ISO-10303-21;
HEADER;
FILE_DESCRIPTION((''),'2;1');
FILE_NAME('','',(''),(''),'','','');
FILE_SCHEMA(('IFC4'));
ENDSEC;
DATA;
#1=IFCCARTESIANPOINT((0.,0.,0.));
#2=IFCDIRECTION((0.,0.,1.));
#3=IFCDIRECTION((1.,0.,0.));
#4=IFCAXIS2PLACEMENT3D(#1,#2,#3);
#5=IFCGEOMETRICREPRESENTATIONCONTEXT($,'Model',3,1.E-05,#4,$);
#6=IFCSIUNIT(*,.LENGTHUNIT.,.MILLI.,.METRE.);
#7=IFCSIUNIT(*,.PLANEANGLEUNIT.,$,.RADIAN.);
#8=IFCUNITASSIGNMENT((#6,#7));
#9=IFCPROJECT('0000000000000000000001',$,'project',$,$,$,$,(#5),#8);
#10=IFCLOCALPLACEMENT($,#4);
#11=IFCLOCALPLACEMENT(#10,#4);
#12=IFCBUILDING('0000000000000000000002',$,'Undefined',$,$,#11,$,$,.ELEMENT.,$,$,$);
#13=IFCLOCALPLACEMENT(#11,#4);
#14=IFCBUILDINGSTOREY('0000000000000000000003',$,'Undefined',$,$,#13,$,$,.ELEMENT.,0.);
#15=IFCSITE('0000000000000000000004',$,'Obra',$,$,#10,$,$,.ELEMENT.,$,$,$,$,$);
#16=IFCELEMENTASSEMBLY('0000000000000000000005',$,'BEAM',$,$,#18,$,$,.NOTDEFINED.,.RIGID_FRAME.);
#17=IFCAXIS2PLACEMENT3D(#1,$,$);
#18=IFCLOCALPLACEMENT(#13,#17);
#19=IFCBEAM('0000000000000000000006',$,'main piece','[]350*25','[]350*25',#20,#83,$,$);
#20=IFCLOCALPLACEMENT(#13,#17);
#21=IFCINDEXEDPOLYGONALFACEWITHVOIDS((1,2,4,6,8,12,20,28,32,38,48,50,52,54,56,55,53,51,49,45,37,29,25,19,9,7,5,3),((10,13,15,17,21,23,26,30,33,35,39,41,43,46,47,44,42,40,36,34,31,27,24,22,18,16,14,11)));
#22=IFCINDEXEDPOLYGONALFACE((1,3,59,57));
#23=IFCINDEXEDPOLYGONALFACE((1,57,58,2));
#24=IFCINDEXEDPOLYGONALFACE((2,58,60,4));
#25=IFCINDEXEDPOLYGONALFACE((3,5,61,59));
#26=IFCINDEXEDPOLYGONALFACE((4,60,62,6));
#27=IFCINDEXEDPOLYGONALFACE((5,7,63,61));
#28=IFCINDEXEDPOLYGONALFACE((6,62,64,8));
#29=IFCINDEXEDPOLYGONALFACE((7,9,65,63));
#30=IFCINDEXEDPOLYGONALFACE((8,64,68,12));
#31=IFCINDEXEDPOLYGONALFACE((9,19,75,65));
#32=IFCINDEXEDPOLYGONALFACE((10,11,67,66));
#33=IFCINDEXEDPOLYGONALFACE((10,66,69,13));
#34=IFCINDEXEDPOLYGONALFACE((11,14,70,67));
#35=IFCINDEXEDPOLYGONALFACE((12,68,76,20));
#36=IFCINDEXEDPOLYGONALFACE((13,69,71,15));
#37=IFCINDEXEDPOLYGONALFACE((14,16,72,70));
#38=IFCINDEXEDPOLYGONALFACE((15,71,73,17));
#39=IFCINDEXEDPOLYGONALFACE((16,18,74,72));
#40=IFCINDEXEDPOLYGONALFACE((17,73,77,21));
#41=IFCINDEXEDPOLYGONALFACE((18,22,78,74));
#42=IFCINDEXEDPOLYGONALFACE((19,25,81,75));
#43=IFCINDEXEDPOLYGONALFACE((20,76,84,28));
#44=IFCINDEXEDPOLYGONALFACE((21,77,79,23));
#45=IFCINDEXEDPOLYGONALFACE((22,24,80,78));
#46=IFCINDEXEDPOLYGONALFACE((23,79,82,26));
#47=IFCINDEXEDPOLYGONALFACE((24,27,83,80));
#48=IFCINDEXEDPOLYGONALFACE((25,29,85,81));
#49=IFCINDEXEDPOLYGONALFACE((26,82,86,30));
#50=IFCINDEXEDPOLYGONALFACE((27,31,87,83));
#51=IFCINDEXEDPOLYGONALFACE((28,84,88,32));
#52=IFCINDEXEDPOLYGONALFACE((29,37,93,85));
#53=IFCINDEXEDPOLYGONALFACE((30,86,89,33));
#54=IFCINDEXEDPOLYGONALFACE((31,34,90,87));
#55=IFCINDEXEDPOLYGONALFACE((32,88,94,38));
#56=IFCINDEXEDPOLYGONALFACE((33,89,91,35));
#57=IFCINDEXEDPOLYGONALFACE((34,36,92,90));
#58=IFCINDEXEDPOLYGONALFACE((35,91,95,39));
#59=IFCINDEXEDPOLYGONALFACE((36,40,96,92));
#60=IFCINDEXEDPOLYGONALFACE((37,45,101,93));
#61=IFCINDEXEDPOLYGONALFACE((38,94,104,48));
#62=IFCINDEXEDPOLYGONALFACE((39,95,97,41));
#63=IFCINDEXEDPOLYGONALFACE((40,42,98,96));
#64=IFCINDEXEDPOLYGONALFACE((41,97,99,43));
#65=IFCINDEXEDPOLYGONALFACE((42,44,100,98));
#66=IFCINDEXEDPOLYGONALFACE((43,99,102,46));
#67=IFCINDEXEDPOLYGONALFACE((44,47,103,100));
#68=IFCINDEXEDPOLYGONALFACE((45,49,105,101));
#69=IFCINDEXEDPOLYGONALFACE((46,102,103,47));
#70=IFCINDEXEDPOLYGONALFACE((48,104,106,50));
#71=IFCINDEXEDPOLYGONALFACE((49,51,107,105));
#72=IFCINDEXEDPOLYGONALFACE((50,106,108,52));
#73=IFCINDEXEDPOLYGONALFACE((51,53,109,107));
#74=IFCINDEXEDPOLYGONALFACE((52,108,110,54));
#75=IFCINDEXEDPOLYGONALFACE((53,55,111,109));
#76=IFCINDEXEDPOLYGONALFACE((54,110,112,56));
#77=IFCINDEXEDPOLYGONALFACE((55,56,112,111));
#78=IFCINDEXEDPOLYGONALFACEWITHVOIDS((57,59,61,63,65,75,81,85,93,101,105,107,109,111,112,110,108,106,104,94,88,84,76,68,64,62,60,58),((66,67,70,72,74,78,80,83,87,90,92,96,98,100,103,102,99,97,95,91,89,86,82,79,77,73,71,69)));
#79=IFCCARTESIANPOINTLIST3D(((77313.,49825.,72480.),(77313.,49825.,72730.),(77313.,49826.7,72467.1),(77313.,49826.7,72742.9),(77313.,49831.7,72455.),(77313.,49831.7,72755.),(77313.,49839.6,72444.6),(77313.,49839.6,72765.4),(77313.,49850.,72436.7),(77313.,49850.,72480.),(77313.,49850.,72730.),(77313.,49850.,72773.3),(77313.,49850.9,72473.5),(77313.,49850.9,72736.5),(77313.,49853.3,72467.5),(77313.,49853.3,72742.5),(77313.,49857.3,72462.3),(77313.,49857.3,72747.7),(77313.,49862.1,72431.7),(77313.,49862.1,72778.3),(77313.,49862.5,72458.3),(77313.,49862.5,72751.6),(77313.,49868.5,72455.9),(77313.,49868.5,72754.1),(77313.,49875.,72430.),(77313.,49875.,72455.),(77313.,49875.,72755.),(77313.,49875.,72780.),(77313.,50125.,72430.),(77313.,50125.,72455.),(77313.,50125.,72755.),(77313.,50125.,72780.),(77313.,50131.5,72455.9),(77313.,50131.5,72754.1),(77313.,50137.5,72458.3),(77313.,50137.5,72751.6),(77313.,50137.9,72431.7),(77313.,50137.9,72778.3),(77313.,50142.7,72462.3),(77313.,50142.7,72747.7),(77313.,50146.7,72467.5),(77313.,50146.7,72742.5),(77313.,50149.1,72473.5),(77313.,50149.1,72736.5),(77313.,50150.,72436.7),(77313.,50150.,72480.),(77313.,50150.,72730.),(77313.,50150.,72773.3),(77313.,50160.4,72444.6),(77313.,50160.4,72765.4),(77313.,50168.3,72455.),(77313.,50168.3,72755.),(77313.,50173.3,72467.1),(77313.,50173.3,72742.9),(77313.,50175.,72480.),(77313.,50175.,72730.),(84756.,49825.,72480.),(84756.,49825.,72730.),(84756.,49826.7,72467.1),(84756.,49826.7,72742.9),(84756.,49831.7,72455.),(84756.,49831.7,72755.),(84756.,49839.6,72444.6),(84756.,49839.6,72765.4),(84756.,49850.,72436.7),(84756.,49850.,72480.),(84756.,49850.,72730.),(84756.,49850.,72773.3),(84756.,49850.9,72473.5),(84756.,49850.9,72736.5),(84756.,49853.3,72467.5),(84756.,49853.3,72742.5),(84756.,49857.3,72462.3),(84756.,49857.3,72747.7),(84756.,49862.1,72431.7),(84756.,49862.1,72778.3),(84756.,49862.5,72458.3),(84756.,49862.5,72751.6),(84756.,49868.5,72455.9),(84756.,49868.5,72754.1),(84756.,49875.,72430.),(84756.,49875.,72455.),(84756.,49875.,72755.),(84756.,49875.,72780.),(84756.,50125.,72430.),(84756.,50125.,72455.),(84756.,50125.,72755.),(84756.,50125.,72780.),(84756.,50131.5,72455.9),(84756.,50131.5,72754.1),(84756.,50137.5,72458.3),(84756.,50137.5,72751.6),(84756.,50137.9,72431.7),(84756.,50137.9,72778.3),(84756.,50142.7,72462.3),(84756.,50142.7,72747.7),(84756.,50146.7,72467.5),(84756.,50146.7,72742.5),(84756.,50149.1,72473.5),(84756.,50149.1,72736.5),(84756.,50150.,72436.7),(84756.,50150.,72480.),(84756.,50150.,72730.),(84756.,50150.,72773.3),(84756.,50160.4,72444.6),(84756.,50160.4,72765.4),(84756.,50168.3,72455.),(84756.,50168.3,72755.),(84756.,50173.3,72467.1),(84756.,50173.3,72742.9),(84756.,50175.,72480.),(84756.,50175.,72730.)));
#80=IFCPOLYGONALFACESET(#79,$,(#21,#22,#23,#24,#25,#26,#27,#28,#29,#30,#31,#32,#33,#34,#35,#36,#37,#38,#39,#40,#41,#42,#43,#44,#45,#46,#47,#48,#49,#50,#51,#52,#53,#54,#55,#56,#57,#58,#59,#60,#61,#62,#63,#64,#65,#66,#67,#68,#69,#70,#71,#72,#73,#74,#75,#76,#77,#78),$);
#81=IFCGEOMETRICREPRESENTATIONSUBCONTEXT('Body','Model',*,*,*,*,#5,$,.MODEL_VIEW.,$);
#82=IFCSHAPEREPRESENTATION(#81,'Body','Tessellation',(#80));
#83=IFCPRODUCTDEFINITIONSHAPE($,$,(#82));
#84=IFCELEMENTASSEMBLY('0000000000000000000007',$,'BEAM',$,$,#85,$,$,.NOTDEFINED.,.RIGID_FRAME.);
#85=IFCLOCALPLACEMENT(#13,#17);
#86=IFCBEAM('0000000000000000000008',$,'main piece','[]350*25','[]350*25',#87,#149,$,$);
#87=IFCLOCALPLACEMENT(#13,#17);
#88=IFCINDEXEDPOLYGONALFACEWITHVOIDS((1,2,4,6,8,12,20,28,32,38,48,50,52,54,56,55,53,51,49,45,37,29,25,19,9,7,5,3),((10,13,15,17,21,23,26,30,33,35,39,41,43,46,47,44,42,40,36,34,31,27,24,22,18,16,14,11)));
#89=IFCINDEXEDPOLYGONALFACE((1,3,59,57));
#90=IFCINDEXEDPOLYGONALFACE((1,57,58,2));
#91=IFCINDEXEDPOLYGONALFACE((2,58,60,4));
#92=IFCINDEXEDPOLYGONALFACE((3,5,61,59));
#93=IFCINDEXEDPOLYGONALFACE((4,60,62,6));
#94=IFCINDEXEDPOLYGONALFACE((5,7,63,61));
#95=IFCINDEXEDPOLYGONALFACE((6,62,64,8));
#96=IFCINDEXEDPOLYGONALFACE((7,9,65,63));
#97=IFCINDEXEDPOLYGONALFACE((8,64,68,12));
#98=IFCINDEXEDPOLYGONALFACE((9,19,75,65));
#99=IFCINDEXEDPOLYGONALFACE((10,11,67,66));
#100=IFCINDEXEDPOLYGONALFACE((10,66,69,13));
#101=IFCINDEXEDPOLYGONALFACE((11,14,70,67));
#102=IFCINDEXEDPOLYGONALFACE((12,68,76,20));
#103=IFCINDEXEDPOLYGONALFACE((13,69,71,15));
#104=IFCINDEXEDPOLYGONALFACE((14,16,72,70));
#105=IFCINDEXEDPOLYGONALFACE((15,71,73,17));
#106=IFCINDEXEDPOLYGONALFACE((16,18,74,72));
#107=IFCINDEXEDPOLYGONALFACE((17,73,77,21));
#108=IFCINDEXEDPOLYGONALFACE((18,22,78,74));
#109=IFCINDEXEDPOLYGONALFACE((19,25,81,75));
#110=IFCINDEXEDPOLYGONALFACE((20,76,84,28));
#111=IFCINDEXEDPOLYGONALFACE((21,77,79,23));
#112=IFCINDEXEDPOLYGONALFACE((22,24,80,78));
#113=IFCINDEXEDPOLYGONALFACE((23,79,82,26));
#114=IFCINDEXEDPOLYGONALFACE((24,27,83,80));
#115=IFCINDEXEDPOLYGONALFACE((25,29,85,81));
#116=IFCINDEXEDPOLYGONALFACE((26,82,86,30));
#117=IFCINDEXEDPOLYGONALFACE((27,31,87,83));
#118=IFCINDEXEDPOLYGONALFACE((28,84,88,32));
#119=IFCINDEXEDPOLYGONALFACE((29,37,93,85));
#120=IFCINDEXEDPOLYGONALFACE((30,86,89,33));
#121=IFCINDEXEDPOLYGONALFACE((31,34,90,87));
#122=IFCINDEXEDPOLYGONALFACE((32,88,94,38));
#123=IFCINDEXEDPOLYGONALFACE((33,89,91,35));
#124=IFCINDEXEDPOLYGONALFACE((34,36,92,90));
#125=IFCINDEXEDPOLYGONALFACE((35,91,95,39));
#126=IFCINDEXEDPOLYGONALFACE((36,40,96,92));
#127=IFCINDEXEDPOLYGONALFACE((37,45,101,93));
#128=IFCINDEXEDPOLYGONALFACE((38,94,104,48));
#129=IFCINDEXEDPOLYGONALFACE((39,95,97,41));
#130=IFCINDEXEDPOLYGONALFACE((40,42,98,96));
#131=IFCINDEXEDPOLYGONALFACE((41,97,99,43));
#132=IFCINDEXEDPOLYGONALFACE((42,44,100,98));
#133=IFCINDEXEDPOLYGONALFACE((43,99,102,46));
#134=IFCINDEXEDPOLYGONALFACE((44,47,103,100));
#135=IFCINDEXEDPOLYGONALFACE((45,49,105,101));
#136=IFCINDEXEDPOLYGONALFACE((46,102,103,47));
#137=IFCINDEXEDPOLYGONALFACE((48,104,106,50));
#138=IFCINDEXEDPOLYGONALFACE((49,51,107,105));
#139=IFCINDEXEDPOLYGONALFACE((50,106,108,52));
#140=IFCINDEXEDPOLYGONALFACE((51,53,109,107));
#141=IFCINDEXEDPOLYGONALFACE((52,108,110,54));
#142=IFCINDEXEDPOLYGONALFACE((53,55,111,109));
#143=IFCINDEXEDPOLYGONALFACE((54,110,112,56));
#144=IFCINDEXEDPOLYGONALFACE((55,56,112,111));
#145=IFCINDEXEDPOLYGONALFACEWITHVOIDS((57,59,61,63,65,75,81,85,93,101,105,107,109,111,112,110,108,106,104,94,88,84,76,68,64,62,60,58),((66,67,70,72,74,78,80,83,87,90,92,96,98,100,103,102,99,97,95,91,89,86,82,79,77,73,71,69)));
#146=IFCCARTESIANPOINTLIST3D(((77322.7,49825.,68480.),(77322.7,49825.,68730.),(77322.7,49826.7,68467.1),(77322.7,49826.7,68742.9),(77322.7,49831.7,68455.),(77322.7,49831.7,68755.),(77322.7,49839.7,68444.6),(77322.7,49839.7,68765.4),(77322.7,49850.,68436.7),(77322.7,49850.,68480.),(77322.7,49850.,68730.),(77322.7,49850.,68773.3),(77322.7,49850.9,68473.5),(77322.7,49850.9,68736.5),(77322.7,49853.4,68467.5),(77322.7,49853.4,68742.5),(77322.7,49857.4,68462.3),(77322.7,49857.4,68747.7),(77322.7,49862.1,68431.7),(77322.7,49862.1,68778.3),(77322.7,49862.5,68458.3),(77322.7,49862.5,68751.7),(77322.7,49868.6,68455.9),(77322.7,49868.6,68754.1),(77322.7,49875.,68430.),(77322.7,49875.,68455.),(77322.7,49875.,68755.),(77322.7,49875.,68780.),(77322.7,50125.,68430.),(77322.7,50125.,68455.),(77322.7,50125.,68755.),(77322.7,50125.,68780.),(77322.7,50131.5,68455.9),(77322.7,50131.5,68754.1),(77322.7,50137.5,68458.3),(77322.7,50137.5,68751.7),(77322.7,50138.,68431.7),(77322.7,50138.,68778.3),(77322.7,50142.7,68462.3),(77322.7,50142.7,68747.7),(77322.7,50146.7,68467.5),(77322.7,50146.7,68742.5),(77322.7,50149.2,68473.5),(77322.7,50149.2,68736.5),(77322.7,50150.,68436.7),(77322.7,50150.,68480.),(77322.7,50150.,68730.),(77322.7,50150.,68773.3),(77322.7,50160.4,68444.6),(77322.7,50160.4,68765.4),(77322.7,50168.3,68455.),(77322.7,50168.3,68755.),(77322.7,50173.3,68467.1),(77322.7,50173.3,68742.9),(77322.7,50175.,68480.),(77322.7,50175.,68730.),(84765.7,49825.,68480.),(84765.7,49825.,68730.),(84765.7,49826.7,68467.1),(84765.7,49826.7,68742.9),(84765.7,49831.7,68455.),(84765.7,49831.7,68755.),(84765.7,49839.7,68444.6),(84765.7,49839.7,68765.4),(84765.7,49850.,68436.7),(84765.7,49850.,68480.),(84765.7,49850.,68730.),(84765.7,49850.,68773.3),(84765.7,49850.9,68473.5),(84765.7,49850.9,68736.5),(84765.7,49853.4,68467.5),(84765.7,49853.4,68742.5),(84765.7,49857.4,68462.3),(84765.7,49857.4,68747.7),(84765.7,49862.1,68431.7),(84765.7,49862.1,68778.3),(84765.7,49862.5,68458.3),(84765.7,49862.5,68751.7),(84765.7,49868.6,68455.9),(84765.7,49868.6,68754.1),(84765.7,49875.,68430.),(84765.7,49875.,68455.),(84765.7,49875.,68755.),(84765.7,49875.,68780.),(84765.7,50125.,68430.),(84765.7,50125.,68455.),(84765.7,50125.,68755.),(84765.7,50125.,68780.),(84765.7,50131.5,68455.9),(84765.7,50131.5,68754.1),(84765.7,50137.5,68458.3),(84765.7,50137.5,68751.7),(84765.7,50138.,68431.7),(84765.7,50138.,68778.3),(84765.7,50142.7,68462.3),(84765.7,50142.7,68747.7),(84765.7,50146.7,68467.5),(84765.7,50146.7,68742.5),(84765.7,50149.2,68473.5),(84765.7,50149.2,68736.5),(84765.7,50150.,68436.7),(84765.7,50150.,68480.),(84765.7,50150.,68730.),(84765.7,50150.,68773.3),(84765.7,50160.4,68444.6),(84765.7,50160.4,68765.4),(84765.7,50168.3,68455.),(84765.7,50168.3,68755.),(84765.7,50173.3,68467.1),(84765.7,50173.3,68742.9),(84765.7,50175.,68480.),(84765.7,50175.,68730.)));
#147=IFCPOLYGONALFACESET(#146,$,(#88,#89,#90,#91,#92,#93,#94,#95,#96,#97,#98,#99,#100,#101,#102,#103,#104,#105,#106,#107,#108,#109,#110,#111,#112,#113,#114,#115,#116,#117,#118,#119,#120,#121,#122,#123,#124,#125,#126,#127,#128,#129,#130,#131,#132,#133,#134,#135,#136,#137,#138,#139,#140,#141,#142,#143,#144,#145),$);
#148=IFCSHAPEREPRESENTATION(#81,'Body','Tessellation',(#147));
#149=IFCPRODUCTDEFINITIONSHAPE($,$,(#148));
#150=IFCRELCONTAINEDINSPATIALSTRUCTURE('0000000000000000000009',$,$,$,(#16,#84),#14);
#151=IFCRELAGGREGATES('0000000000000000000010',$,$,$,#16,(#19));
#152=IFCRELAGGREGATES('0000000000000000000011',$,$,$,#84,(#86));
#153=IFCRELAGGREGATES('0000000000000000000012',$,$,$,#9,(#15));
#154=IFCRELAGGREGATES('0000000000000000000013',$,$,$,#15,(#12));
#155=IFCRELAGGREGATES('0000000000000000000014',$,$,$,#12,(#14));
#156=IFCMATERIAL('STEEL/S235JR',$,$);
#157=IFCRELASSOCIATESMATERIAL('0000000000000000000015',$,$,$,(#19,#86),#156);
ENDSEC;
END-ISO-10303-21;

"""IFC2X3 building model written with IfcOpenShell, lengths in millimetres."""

from ifc_helpers import new_model, si_unit, frame, origin_with_axes, origin_2d_with_axis, place, context, subcontext, project, spatial, hollow_rectangle, extrude, material, element, aggregate, save


model = new_model("IFC2X3")

# Units and contexts
model_context = context("Model", 3, precision=1e-05, world=origin_with_axes())
body_context = subcontext(model_context, "Body", "Model", "MODEL_VIEW")
ifc_project = project(units=[si_unit("LENGTHUNIT", "METRE", prefix="MILLI"), si_unit("PLANEANGLEUNIT", "RADIAN")], contexts=[model_context])

# Site, building, storey
site_placement = place(None, origin_with_axes())
site = spatial("IfcSite", under=ifc_project, at=site_placement, Name="Obra", CompositionType="ELEMENT")
building_placement = place(site_placement, origin_with_axes())
building = spatial("IfcBuilding", under=site, at=building_placement, Name="Undefined", CompositionType="ELEMENT")
storey_placement = place(building_placement, origin_with_axes())
storey = spatial("IfcBuildingStorey", under=building, at=storey_placement, Name="Undefined", CompositionType="ELEMENT", Elevation=0.0)

# Shared definitions
ifc_material = material(Name="STEEL/S235JR")

# Element assemblies, beams
assembly_1_placement = place(storey_placement, origin_with_axes())
assembly_1 = element("IfcElementAssembly", 1, at=assembly_1_placement, inside=storey, Name="BEAM", AssemblyPlace="NOTDEFINED", PredefinedType="RIGID_FRAME")
beam_1_placement = place(assembly_1_placement, frame((84756.0, 50000.0, 72605.0), z_axis=(0.0, 0.0, 1.0), x_axis=(-1.0, 0.0, 0.0)))
beam_1 = element("IfcBeam", 2, at=beam_1_placement, material=ifc_material, Name="main piece", Description="[]350*25", ObjectType="[]350*25", context=body_context, shape_type="SweptSolid", body=[
    extrude(hollow_rectangle(XDim=350.0, YDim=350.0, WallThickness=25.0, InnerFilletRadius=25.0, OuterFilletRadius=50.0, at=origin_2d_with_axis()), frame((7443.0, 0.0, 0.0), z_axis=(-1.0, 0.0, 0.0), x_axis=(0.0, -1.0, 0.0)), (0.0, 0.0, 1.0), 7443.0),
])
aggregate(assembly_1, [beam_1])
assembly_2_placement = place(storey_placement, origin_with_axes())
assembly_2 = element("IfcElementAssembly", 3, at=assembly_2_placement, inside=storey, Name="BEAM", AssemblyPlace="NOTDEFINED", PredefinedType="RIGID_FRAME")
beam_2_placement = place(assembly_2_placement, frame((84765.7, 50000.0, 68605.0), z_axis=(0.0, 0.0, 1.0), x_axis=(-1.0, 0.0, 0.0)))
beam_2 = element("IfcBeam", 4, at=beam_2_placement, material=ifc_material, Name="main piece", Description="[]350*25", ObjectType="[]350*25", context=body_context, shape_type="SweptSolid", body=[
    extrude(hollow_rectangle(XDim=350.0, YDim=350.0, WallThickness=25.0, InnerFilletRadius=25.0, OuterFilletRadius=50.0, at=origin_2d_with_axis()), frame((7443.0, 0.0, 0.0), z_axis=(-1.0, 0.0, 0.0), x_axis=(0.0, -1.0, 0.0)), (0.0, 0.0, 1.0), 7443.0),
])
aggregate(assembly_2, [beam_2])

save(model, "model.ifc")
